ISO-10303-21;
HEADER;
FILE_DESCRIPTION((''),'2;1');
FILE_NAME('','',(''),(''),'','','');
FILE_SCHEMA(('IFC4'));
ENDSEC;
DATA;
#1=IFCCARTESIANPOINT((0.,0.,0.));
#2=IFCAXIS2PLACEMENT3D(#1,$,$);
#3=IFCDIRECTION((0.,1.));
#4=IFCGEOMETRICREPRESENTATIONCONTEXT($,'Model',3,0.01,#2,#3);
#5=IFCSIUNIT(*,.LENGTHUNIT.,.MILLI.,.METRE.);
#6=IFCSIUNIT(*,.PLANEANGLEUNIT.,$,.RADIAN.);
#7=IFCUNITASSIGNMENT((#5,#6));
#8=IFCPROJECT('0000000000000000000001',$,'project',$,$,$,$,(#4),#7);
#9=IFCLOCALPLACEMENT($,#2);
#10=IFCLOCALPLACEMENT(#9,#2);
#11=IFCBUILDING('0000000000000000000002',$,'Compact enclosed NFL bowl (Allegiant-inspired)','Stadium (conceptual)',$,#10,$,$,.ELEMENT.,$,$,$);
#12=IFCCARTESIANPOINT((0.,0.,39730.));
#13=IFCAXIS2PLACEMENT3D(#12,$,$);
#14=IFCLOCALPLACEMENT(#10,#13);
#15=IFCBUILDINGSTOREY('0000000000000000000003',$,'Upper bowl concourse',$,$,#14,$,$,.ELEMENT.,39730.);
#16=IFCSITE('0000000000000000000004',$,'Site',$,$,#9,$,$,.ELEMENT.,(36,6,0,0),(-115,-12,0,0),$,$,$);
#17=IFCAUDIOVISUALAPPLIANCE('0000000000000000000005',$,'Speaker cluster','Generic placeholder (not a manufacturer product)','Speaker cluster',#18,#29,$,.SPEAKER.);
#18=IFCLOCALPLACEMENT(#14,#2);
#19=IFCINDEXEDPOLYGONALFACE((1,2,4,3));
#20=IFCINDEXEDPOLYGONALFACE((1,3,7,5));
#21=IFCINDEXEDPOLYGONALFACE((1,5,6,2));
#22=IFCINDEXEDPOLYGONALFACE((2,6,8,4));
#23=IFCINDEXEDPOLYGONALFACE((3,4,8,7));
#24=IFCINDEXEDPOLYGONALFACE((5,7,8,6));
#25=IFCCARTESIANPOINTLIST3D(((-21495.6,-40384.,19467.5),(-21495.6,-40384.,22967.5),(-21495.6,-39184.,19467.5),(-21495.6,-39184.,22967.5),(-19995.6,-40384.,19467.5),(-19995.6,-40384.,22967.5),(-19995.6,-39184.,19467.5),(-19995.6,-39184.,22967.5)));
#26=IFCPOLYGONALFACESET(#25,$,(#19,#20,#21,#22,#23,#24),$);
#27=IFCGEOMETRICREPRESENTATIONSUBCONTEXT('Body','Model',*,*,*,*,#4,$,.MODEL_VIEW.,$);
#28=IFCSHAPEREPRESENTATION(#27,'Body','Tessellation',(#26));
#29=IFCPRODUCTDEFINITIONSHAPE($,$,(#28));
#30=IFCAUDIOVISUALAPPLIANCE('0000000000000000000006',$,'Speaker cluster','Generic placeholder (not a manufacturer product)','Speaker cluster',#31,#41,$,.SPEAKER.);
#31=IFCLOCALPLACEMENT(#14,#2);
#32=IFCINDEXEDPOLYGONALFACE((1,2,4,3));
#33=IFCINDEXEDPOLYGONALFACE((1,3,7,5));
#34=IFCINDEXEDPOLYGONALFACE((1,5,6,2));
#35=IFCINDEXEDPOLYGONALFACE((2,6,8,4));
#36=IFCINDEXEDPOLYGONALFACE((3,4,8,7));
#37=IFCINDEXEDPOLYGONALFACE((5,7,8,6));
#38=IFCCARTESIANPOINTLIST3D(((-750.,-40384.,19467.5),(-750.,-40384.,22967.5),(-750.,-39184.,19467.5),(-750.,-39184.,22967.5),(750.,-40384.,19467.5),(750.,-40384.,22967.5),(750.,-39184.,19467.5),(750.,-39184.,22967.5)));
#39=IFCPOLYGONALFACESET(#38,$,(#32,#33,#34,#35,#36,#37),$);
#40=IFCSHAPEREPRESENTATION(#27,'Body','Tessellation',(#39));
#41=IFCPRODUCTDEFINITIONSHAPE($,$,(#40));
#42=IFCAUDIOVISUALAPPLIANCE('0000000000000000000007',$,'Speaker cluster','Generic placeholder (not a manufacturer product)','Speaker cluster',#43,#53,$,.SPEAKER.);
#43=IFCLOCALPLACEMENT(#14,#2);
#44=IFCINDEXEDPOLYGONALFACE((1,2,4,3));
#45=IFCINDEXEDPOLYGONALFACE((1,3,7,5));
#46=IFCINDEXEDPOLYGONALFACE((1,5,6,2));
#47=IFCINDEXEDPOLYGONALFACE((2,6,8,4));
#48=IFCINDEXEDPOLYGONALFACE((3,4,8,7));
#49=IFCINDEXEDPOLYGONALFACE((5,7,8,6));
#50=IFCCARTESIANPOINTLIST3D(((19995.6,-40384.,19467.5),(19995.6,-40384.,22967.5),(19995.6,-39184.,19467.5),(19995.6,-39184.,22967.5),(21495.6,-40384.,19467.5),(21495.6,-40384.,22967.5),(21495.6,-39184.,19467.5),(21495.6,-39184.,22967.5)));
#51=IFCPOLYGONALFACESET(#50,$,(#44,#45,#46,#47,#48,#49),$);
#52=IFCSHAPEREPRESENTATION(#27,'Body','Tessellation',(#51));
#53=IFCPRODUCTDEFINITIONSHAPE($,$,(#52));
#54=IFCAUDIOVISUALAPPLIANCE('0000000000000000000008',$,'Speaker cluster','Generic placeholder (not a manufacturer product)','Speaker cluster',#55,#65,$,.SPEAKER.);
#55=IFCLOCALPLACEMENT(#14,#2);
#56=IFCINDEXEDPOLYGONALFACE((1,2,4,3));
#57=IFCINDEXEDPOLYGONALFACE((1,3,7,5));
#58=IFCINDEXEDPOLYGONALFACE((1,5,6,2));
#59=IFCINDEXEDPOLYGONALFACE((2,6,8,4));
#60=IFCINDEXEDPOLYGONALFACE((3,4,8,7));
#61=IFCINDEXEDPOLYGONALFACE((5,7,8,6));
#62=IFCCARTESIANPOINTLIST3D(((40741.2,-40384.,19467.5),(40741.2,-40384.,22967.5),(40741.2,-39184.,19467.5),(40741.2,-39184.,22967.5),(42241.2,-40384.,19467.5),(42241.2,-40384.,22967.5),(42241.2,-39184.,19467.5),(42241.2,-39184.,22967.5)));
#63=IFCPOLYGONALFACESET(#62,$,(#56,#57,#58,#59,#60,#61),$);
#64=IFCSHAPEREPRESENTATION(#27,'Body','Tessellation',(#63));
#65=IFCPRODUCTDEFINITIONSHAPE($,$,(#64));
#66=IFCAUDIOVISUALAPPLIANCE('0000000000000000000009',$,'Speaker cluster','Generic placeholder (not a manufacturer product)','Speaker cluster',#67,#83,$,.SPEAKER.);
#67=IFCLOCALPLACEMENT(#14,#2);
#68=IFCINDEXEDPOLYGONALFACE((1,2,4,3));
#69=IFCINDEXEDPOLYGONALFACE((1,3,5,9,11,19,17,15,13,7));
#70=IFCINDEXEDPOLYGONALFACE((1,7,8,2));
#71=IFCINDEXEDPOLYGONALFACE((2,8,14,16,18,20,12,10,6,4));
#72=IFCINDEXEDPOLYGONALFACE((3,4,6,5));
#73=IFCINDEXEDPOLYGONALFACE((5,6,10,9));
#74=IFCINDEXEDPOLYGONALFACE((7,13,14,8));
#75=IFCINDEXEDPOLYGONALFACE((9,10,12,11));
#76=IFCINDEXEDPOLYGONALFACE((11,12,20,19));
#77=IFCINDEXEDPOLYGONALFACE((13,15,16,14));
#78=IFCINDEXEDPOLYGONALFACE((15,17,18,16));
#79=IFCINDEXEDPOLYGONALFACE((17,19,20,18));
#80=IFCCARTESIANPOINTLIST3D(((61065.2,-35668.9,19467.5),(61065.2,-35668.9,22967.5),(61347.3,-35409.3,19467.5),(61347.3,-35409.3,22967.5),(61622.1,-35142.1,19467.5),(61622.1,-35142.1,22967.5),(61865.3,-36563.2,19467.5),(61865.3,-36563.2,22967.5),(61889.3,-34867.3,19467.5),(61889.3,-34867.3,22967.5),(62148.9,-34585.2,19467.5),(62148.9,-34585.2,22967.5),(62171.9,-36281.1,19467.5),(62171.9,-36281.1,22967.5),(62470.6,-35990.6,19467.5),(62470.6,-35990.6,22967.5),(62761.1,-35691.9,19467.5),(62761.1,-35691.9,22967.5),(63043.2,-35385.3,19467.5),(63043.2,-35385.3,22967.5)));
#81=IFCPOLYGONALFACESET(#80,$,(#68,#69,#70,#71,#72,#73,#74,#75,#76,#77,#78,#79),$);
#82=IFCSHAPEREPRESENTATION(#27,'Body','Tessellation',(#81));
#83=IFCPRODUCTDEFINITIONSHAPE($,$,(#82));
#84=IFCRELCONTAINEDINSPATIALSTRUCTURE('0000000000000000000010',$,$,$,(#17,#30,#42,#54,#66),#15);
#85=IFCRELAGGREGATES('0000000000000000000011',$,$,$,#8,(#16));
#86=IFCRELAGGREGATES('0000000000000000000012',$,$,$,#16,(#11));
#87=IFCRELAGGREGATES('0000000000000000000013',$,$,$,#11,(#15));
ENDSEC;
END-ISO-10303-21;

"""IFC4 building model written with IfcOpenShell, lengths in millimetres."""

from ifc_helpers import new_model, si_unit, direction, frame, origin, place, context, subcontext, project, spatial, line, arc, indexed_curve, outline, extrude, element, save


model = new_model("IFC4")

# Units and contexts
model_context = context("Model", 3, precision=0.01, world=origin(), true_north=direction((0.0, 1.0)))
body_context = subcontext(model_context, "Body", "Model", "MODEL_VIEW")
ifc_project = project(units=[si_unit("LENGTHUNIT", "METRE", prefix="MILLI"), si_unit("PLANEANGLEUNIT", "RADIAN")], contexts=[model_context])

# Site, building, storey
site_placement = place(None, origin())
site = spatial("IfcSite", under=ifc_project, at=site_placement, Name="Site", CompositionType="ELEMENT", RefLatitude=(36, 6, 0, 0), RefLongitude=(-115, -12, 0, 0))
building_placement = place(site_placement, origin())
building = spatial("IfcBuilding", under=site, at=building_placement, Name="Compact enclosed NFL bowl (Allegiant-inspired)", Description="Stadium (conceptual)", CompositionType="ELEMENT")
storey_placement = place(building_placement, frame((0.0, 0.0, 39730.0)))
storey = spatial("IfcBuildingStorey", under=building, at=storey_placement, Name="Upper bowl concourse", CompositionType="ELEMENT", Elevation=39730.0)

# Shared definitions
placement = place(storey_placement, frame((0.0, 0.0, -39730.0)))

# Audio visual appliances
element("IfcAudioVisualAppliance", 1, at=placement, inside=storey, Name="Speaker cluster", Description="Generic placeholder (not a manufacturer product)", ObjectType="Speaker cluster", PredefinedType="SPEAKER", context=body_context, shape_type="SweptSolid", body=[
    extrude(outline(indexed_curve([(-21495.6, -39184.0), (-19995.6, -39184.0), (-19995.6, -40384.0), (-21495.6, -40384.0)], segments=[line(1, 2), line(2, 3), line(3, 4), line(4, 1)], self_intersect=False)), frame((0.0, 0.0, 59197.5)), (0.0, 0.0, 1.0), 3500.0),
])
element("IfcAudioVisualAppliance", 2, at=placement, inside=storey, Name="Speaker cluster", Description="Generic placeholder (not a manufacturer product)", ObjectType="Speaker cluster", PredefinedType="SPEAKER", context=body_context, shape_type="SweptSolid", body=[
    extrude(outline(indexed_curve([(-750.0, -39184.0), (750.0, -39184.0), (750.0, -40384.0), (-750.0, -40384.0)], segments=[line(1, 2), line(2, 3), line(3, 4), line(4, 1)], self_intersect=False)), frame((0.0, 0.0, 59197.5)), (0.0, 0.0, 1.0), 3500.0),
])
element("IfcAudioVisualAppliance", 3, at=placement, inside=storey, Name="Speaker cluster", Description="Generic placeholder (not a manufacturer product)", ObjectType="Speaker cluster", PredefinedType="SPEAKER", context=body_context, shape_type="SweptSolid", body=[
    extrude(outline(indexed_curve([(19995.6, -39184.0), (21495.6, -39184.0), (21495.6, -40384.0), (19995.6, -40384.0)], segments=[line(1, 2), line(2, 3), line(3, 4), line(4, 1)], self_intersect=False)), frame((0.0, 0.0, 59197.5)), (0.0, 0.0, 1.0), 3500.0),
])
element("IfcAudioVisualAppliance", 4, at=placement, inside=storey, Name="Speaker cluster", Description="Generic placeholder (not a manufacturer product)", ObjectType="Speaker cluster", PredefinedType="SPEAKER", context=body_context, shape_type="SweptSolid", body=[
    extrude(outline(indexed_curve([(40741.2, -39184.0), (42241.2, -39184.0), (42241.2, -40384.0), (40741.2, -40384.0)], segments=[line(1, 2), line(2, 3), line(3, 4), line(4, 1)], self_intersect=False)), frame((0.0, 0.0, 59197.5)), (0.0, 0.0, 1.0), 3500.0),
])
element("IfcAudioVisualAppliance", 5, at=placement, inside=storey, Name="Speaker cluster", Description="Generic placeholder (not a manufacturer product)", ObjectType="Speaker cluster", PredefinedType="SPEAKER", context=body_context, shape_type="SweptSolid", body=[
    extrude(outline(indexed_curve([(61065.2, -35668.9), (61622.1, -35142.1), (62148.9, -34585.2), (63043.2, -35385.3), (62470.6, -35990.6), (61865.3, -36563.2)], segments=[arc(1, 2, 3), line(3, 4), arc(4, 5, 6), line(6, 1)], self_intersect=False)), frame((0.0, 0.0, 59197.5)), (0.0, 0.0, 1.0), 3500.0),
])

save(model, "model.ifc")
